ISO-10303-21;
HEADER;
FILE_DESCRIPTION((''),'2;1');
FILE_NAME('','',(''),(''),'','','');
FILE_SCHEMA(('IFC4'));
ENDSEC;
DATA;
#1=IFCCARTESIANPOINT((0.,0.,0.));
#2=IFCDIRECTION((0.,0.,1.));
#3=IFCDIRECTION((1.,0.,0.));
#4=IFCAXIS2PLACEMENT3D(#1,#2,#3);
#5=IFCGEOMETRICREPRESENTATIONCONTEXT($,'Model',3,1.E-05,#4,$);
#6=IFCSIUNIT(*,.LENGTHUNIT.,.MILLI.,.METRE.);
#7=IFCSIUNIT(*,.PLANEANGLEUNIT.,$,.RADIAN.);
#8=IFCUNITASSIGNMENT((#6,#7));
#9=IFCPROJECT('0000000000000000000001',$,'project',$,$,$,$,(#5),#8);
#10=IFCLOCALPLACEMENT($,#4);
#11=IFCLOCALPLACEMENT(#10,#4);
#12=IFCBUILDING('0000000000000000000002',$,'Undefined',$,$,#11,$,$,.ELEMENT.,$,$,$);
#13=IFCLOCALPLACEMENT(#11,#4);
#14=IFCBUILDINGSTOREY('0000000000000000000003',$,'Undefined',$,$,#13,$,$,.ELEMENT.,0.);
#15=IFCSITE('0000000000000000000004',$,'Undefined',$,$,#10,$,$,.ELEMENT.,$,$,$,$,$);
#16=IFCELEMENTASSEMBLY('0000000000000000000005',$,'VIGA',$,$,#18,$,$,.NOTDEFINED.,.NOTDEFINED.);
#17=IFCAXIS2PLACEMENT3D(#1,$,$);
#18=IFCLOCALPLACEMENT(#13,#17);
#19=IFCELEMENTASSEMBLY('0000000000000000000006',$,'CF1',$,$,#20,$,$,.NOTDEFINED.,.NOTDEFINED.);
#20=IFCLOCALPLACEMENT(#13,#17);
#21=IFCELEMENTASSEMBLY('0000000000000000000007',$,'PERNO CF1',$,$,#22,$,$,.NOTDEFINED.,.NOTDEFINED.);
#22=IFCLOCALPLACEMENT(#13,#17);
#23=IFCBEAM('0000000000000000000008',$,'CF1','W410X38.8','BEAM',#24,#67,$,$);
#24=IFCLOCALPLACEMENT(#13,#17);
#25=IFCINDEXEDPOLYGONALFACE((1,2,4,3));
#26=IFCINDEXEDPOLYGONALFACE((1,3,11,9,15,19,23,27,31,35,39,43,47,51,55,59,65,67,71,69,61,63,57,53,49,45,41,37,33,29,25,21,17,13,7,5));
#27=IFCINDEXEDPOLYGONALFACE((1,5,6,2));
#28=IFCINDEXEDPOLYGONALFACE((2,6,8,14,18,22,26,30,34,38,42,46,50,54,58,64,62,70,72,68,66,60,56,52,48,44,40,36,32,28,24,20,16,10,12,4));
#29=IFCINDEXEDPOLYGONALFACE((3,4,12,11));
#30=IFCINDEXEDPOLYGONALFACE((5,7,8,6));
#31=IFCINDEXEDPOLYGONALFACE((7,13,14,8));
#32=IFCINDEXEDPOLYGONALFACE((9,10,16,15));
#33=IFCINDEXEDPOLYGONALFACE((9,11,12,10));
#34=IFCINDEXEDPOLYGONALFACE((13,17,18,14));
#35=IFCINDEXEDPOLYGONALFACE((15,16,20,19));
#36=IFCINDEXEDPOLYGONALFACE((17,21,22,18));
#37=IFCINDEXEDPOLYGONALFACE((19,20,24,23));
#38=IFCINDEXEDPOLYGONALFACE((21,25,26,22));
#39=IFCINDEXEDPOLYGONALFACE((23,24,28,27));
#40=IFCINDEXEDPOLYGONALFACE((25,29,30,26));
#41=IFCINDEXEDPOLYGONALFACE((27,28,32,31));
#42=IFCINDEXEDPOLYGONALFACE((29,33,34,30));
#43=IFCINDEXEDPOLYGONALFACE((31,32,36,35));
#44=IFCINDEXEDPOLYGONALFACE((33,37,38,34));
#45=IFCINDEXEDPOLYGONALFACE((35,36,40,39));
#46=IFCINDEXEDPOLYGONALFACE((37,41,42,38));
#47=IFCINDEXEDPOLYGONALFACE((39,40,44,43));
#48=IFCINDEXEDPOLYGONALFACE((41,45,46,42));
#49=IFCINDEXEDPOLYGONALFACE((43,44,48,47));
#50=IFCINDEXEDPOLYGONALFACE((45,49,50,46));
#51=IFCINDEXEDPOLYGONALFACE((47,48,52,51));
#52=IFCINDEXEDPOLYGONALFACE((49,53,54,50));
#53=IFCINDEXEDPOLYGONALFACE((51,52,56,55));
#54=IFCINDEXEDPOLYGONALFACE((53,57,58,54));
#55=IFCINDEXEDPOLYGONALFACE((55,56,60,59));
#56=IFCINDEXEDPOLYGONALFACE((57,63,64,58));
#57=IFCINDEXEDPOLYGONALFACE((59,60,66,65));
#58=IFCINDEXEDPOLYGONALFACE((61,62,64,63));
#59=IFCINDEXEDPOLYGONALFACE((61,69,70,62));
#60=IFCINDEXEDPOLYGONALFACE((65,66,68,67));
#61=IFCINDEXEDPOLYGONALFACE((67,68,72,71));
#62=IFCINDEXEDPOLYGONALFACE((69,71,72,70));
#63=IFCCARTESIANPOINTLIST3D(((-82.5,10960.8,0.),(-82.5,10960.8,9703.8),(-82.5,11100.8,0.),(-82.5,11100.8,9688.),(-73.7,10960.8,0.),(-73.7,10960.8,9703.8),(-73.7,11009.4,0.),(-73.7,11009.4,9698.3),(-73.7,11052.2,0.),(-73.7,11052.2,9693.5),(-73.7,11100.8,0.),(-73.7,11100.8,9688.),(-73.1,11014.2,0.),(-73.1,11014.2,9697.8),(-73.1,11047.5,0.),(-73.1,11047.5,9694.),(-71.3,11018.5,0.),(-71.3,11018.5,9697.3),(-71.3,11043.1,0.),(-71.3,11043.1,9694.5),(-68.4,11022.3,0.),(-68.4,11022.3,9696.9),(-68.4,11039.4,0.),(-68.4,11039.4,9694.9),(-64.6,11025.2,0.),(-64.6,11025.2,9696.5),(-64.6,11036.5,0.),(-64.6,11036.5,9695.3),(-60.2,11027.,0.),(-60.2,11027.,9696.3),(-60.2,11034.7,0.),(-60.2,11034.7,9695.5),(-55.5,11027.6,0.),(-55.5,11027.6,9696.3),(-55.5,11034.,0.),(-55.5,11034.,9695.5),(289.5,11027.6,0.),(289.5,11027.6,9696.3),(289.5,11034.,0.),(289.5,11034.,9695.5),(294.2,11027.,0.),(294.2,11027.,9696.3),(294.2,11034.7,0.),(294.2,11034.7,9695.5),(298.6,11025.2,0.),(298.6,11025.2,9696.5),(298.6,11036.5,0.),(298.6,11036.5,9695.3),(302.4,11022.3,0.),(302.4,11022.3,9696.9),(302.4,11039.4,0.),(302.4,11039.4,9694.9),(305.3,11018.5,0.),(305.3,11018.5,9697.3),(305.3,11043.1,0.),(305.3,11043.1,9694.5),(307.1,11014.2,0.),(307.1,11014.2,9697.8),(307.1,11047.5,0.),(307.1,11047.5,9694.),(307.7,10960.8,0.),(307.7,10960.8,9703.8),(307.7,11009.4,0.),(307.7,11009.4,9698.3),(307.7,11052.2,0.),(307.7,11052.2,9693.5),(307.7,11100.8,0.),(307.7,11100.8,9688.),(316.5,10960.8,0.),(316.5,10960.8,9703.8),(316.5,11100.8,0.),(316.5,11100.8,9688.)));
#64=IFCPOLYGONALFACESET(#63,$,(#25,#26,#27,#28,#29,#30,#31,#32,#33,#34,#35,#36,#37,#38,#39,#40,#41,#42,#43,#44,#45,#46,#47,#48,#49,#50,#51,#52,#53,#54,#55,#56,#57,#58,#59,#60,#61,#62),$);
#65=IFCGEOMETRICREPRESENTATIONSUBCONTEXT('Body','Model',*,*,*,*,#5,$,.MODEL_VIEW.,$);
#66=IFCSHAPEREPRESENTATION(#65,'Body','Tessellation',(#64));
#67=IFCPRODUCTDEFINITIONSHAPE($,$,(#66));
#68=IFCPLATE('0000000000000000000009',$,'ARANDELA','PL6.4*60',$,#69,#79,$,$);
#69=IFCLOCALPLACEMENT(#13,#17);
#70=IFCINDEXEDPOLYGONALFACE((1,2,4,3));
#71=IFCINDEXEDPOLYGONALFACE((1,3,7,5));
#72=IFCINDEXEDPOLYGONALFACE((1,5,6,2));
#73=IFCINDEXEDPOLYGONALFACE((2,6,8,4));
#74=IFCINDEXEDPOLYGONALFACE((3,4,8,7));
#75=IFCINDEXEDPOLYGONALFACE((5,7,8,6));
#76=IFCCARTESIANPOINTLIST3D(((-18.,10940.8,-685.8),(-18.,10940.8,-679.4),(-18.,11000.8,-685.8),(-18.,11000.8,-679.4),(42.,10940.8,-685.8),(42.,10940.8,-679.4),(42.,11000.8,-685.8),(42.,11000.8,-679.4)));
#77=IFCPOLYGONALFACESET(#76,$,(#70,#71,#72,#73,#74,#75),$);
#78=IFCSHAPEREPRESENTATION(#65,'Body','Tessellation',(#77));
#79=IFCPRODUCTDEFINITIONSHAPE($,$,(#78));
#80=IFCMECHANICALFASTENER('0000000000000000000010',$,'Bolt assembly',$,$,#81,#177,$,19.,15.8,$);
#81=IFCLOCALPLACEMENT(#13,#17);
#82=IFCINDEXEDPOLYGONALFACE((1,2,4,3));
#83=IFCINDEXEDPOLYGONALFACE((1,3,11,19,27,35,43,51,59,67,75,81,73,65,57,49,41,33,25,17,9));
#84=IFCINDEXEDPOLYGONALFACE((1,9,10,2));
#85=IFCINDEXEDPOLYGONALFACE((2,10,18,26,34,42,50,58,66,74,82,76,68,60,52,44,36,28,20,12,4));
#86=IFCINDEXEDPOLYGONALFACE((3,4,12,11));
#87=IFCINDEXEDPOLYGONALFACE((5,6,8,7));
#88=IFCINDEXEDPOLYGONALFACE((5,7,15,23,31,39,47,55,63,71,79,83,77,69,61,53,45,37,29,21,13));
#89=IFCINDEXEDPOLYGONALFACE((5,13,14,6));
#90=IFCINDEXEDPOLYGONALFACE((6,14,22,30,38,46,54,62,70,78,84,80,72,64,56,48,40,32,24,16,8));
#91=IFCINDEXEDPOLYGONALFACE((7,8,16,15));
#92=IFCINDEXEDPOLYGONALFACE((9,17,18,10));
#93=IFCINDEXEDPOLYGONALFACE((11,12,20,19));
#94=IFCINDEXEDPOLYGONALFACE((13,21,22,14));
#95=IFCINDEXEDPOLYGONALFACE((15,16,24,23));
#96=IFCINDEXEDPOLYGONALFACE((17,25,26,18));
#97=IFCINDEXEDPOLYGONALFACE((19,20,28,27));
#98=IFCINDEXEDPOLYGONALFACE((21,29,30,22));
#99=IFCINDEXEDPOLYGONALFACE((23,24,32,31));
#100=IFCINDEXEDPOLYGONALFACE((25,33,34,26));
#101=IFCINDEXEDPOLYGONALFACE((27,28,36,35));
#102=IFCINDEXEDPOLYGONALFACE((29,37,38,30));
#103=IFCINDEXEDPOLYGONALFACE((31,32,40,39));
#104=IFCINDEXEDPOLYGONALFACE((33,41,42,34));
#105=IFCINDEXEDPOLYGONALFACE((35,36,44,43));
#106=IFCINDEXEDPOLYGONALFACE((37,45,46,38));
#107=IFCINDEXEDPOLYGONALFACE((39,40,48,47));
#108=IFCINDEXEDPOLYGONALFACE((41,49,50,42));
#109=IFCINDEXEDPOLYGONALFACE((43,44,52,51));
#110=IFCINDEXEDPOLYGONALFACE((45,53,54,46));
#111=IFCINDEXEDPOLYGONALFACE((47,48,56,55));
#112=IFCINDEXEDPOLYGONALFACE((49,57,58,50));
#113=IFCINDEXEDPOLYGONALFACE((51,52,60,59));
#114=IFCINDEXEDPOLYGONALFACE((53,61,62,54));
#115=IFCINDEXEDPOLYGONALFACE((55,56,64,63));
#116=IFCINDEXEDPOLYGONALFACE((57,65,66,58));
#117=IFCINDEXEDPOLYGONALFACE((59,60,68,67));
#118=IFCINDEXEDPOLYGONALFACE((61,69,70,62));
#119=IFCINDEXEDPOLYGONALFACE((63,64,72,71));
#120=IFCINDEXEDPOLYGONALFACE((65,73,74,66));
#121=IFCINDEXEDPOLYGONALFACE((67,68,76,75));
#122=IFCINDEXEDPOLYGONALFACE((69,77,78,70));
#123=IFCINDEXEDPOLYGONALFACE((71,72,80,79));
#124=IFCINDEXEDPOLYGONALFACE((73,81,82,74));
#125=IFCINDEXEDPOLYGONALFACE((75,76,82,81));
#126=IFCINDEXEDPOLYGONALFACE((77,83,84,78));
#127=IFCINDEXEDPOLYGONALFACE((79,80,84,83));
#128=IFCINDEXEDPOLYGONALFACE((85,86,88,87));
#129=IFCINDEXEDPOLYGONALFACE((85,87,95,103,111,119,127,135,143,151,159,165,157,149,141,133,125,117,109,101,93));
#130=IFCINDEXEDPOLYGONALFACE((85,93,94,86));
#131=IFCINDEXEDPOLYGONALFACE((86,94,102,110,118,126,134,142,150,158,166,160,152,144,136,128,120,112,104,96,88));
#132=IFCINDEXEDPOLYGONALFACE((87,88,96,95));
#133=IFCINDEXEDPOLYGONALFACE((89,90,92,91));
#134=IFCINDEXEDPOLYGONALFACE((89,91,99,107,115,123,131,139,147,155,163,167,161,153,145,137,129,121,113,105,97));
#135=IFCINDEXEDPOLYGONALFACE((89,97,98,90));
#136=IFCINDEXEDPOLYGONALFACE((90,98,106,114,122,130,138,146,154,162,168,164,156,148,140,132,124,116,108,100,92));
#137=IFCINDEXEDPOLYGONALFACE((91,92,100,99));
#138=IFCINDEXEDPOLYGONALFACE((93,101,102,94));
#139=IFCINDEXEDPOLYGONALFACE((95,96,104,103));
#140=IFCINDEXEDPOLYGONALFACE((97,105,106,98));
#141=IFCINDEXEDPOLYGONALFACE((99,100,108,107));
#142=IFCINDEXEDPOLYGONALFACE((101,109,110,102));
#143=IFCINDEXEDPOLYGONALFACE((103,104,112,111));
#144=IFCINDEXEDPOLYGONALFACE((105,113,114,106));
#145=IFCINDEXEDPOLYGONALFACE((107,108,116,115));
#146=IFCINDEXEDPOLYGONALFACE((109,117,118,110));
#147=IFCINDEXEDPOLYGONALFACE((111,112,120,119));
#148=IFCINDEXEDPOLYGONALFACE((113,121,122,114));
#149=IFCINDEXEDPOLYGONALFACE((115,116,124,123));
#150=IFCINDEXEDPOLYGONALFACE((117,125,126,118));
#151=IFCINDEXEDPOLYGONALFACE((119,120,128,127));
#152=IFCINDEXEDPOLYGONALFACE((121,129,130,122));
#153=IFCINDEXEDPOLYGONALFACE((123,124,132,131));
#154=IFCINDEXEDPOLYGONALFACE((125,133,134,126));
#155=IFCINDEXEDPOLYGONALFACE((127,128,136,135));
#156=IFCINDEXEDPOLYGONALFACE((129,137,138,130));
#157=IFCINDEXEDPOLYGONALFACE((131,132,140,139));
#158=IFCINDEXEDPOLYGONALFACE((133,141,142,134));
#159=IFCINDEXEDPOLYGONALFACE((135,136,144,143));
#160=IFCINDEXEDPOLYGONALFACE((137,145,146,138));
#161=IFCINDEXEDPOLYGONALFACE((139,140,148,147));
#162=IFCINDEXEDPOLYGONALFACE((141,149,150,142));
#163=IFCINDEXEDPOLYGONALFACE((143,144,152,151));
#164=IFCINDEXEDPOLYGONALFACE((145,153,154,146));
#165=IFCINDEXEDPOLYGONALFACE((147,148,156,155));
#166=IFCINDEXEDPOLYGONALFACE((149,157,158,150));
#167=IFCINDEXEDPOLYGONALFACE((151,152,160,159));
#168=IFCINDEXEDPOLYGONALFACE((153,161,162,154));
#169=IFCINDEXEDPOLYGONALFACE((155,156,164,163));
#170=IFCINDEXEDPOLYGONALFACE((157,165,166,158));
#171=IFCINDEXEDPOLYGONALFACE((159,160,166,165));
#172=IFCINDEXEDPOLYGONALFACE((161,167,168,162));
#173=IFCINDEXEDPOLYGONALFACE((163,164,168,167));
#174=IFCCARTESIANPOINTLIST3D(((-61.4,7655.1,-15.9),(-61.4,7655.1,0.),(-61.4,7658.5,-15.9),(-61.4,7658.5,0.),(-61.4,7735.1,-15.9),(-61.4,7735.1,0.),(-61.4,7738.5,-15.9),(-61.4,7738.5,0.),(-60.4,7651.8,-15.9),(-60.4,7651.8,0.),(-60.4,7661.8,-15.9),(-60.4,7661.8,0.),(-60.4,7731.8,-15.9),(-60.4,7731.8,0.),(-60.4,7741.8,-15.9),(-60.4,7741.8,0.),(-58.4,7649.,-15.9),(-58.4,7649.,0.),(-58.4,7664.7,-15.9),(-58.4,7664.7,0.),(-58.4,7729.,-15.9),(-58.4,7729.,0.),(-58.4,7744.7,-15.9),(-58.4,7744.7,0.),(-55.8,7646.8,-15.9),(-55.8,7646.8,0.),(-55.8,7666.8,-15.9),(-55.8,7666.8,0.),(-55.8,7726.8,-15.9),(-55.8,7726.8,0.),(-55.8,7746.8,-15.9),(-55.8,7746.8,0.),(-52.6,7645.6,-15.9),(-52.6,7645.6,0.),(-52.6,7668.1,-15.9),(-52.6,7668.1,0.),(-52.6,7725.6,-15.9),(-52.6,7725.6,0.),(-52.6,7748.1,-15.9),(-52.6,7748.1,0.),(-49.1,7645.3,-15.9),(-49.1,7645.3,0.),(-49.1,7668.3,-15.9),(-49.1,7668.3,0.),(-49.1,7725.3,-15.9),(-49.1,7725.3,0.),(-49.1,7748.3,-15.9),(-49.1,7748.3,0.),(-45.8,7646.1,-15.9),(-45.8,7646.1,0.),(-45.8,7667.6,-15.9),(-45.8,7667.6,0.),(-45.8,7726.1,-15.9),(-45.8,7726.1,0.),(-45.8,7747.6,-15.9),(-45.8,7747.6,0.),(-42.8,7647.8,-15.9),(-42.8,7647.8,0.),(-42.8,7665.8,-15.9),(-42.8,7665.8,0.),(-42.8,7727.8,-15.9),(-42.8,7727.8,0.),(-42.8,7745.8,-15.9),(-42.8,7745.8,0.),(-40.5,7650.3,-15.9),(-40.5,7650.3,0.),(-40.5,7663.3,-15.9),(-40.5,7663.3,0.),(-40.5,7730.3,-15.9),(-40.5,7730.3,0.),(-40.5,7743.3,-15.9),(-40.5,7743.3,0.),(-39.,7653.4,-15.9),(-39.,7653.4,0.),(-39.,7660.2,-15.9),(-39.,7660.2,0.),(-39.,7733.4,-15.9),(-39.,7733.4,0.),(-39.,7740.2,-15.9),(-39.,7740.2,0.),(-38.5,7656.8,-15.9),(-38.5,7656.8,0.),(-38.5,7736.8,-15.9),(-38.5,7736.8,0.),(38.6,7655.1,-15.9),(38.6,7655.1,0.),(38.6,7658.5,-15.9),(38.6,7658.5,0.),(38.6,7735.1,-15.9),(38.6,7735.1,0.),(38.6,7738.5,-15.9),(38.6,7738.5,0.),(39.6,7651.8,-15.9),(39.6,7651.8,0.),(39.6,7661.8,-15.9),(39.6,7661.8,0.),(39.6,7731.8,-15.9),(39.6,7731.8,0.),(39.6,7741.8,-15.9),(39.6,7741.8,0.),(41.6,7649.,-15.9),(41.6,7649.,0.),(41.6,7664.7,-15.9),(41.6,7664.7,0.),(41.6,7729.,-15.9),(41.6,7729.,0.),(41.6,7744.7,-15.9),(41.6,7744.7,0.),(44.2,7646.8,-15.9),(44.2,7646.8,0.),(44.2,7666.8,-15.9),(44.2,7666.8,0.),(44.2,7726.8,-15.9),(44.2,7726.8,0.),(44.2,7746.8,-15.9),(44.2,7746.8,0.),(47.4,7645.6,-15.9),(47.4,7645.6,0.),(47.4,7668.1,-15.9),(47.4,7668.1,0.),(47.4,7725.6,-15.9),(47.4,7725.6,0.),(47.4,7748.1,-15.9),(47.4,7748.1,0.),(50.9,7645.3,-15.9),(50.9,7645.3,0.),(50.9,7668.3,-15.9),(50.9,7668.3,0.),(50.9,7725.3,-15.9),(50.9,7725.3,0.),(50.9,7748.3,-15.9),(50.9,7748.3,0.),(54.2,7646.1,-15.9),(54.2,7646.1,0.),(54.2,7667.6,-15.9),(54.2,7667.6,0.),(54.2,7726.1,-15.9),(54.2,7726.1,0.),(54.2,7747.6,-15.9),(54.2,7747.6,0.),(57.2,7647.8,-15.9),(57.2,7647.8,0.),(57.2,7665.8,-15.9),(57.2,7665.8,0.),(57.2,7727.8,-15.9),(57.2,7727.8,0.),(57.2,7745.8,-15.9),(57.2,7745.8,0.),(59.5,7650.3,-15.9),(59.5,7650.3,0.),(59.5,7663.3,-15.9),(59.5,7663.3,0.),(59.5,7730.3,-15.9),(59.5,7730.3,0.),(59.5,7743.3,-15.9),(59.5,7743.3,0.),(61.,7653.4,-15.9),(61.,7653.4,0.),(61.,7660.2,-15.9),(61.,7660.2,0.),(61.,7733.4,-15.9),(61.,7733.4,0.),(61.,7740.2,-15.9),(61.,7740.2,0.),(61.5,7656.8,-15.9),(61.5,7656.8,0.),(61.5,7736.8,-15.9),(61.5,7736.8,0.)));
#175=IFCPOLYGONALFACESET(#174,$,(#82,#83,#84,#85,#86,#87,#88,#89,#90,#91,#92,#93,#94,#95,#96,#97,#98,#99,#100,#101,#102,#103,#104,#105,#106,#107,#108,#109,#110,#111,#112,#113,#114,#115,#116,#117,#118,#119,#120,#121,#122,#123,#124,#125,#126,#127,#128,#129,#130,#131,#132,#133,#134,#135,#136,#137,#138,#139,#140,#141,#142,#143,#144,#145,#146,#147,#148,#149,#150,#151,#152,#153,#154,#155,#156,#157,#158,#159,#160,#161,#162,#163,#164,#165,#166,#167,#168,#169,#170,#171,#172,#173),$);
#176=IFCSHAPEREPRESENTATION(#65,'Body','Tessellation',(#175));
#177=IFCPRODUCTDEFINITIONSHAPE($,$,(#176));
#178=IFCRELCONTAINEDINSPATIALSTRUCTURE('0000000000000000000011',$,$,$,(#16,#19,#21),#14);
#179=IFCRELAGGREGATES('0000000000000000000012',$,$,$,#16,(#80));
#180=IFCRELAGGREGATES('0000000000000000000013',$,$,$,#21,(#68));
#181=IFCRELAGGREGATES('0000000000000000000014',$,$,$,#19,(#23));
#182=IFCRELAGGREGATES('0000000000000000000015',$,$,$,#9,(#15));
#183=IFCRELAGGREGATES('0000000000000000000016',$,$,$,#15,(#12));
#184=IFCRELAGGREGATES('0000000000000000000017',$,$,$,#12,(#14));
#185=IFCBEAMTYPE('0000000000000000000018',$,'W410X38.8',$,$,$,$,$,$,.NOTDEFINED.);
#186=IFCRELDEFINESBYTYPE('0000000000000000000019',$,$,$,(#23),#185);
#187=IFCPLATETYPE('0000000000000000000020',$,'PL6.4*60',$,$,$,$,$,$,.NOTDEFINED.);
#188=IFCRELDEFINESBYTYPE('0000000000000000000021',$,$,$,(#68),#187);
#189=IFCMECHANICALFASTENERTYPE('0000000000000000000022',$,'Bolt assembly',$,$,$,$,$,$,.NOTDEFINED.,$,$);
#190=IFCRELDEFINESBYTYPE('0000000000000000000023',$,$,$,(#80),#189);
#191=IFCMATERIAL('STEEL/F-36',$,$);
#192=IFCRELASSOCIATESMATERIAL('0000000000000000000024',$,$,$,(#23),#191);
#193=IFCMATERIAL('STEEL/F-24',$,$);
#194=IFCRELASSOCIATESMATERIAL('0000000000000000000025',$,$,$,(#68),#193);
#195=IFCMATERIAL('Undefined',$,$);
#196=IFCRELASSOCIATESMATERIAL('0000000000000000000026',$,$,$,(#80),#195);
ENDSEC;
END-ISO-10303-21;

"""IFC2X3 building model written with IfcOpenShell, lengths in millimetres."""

from ifc_helpers import new_model, si_unit, frame, origin_with_axes, origin_2d_with_axis, place, context, subcontext, project, spatial, polyline, circle, i_section, outline, extrude, clip, halfspace, source, transform, mapped, material, type_object, element, aggregate, save


model = new_model("IFC2X3")

# Units and contexts
model_context = context("Model", 3, precision=1e-05, world=origin_with_axes())
body_context = subcontext(model_context, "Body", "Model", "MODEL_VIEW")
ifc_project = project(units=[si_unit("LENGTHUNIT", "METRE", prefix="MILLI"), si_unit("PLANEANGLEUNIT", "RADIAN")], contexts=[model_context])

# Site, building, storey
site_placement = place(None, origin_with_axes())
site = spatial("IfcSite", under=ifc_project, at=site_placement, Name="Undefined", CompositionType="ELEMENT")
building_placement = place(site_placement, origin_with_axes())
building = spatial("IfcBuilding", under=site, at=building_placement, Name="Undefined", CompositionType="ELEMENT")
storey_placement = place(building_placement, origin_with_axes())
storey = spatial("IfcBuildingStorey", under=building, at=storey_placement, Name="Undefined", CompositionType="ELEMENT", Elevation=0.0)

# Element assembly
ifc_material_1 = material(Name="STEEL/F-36")
ifc_material_2 = material(Name="STEEL/F-24")
assembly_1_placement = place(storey_placement, origin_with_axes())
assembly_1 = element("IfcElementAssembly", 1, at=assembly_1_placement, inside=storey, Name="VIGA", AssemblyPlace="NOTDEFINED", PredefinedType="NOTDEFINED")

# Element assembly
assembly_2_placement = place(storey_placement, origin_with_axes())
assembly_2 = element("IfcElementAssembly", 2, at=assembly_2_placement, inside=storey, Name="CF1", AssemblyPlace="NOTDEFINED", PredefinedType="NOTDEFINED")

# Element assembly
assembly_3_placement = place(storey_placement, origin_with_axes())
assembly_3 = element("IfcElementAssembly", 3, at=assembly_3_placement, inside=storey, Name="PERNO CF1", AssemblyPlace="NOTDEFINED", PredefinedType="NOTDEFINED")

# Beam
beam_type_1 = type_object("IfcBeamType", Name="W410X38.8", PredefinedType="NOTDEFINED")
beam_1_placement = place(assembly_2_placement, frame((117.0, 11030.8, 0.0), z_axis=(-1.0, 0.0, 0.0), x_axis=(0.0, 0.0, 1.0)))
beam_1 = element("IfcBeam", 4, at=beam_1_placement, type_object=beam_type_1, material=ifc_material_1, Name="CF1", Description="W410X38.8", ObjectType="BEAM", context=body_context, shape_type="Clipping", body=[
    clip(extrude(i_section(OverallWidth=140.0, OverallDepth=399.0, WebThickness=6.4, FlangeThickness=8.8, FilletRadius=18.2, at=origin_2d_with_axis()), frame((9750.0, 0.0, 0.0), z_axis=(-1.0, 0.0, 0.0), x_axis=(0.0, -1.0, 0.0)), (0.0, 0.0, 1.0), 9750.0), halfspace(frame((9695.9, 0.0, 0.0), z_axis=(0.993634, 0.112653, 0.0), x_axis=(0.112653, -0.993634, 0.0)), False)),
])

# Plate
plate_type = type_object("IfcPlateType", Name="PL6.4*60", PredefinedType="NOTDEFINED")
plate_placement = place(assembly_3_placement, frame((-18.0, 11000.8, -682.6), z_axis=(0.0, 0.0, 1.0), x_axis=(0.0, -1.0, 0.0)))
plate = element("IfcPlate", 5, at=plate_placement, type_object=plate_type, material=ifc_material_2, Name="ARANDELA", Description="PL6.4*60", context=body_context, shape_type="SweptSolid", body=[
    extrude(outline(polyline([(0.0, 0.0), (60.0, 0.0), (60.0, 60.0), (0.0, 60.0), (0.0, 0.0)])), frame((0.0, 0.0, -3.2), z_axis=(0.0, 0.0, 1.0), x_axis=(1.0, 0.0, 0.0)), (0.0, 0.0, 1.0), 6.4),
])

# Mechanical fastener
ifc_material_3 = material(Name="Undefined")
mechanical_fastener_type = type_object("IfcMechanicalFastenerType", Name="Bolt assembly")
shared_shape_1 = source(origin_with_axes(), body_context, "Body", "SweptSolid", [
    extrude(circle(Radius=11.5, at=origin_2d_with_axis()), frame((0.0, 0.0, 0.0), z_axis=(0.0, 1.0, 0.0), x_axis=(1.0, 0.0, 0.0)), (0.0, 0.0, 1.0), 15.9),
])
mechanical_fastener_1_placement = place(assembly_1_placement, frame((-50.0, 7696.8, 0.0), z_axis=(0.0, 1.0, 0.0), x_axis=(1.0, 0.0, 0.0)))
mechanical_fastener_1 = element("IfcMechanicalFastener", 6, at=mechanical_fastener_1_placement, type_object=mechanical_fastener_type, material=ifc_material_3, Name="Bolt assembly", NominalDiameter=19.0, NominalLength=15.8, context=body_context, shape_type="MappedRepresentation", body=[
    mapped(shared_shape_1, transform((0.0, 0.0, -40.0))),
    mapped(shared_shape_1, transform((100.0, 0.0, -40.0))),
    mapped(shared_shape_1, transform((0.0, 0.0, 40.0))),
    mapped(shared_shape_1, transform((100.0, 0.0, 40.0))),
])
aggregate(assembly_1, [mechanical_fastener_1])

aggregate(assembly_3, [plate])
aggregate(assembly_2, [beam_1])

save(model, "model.ifc")
